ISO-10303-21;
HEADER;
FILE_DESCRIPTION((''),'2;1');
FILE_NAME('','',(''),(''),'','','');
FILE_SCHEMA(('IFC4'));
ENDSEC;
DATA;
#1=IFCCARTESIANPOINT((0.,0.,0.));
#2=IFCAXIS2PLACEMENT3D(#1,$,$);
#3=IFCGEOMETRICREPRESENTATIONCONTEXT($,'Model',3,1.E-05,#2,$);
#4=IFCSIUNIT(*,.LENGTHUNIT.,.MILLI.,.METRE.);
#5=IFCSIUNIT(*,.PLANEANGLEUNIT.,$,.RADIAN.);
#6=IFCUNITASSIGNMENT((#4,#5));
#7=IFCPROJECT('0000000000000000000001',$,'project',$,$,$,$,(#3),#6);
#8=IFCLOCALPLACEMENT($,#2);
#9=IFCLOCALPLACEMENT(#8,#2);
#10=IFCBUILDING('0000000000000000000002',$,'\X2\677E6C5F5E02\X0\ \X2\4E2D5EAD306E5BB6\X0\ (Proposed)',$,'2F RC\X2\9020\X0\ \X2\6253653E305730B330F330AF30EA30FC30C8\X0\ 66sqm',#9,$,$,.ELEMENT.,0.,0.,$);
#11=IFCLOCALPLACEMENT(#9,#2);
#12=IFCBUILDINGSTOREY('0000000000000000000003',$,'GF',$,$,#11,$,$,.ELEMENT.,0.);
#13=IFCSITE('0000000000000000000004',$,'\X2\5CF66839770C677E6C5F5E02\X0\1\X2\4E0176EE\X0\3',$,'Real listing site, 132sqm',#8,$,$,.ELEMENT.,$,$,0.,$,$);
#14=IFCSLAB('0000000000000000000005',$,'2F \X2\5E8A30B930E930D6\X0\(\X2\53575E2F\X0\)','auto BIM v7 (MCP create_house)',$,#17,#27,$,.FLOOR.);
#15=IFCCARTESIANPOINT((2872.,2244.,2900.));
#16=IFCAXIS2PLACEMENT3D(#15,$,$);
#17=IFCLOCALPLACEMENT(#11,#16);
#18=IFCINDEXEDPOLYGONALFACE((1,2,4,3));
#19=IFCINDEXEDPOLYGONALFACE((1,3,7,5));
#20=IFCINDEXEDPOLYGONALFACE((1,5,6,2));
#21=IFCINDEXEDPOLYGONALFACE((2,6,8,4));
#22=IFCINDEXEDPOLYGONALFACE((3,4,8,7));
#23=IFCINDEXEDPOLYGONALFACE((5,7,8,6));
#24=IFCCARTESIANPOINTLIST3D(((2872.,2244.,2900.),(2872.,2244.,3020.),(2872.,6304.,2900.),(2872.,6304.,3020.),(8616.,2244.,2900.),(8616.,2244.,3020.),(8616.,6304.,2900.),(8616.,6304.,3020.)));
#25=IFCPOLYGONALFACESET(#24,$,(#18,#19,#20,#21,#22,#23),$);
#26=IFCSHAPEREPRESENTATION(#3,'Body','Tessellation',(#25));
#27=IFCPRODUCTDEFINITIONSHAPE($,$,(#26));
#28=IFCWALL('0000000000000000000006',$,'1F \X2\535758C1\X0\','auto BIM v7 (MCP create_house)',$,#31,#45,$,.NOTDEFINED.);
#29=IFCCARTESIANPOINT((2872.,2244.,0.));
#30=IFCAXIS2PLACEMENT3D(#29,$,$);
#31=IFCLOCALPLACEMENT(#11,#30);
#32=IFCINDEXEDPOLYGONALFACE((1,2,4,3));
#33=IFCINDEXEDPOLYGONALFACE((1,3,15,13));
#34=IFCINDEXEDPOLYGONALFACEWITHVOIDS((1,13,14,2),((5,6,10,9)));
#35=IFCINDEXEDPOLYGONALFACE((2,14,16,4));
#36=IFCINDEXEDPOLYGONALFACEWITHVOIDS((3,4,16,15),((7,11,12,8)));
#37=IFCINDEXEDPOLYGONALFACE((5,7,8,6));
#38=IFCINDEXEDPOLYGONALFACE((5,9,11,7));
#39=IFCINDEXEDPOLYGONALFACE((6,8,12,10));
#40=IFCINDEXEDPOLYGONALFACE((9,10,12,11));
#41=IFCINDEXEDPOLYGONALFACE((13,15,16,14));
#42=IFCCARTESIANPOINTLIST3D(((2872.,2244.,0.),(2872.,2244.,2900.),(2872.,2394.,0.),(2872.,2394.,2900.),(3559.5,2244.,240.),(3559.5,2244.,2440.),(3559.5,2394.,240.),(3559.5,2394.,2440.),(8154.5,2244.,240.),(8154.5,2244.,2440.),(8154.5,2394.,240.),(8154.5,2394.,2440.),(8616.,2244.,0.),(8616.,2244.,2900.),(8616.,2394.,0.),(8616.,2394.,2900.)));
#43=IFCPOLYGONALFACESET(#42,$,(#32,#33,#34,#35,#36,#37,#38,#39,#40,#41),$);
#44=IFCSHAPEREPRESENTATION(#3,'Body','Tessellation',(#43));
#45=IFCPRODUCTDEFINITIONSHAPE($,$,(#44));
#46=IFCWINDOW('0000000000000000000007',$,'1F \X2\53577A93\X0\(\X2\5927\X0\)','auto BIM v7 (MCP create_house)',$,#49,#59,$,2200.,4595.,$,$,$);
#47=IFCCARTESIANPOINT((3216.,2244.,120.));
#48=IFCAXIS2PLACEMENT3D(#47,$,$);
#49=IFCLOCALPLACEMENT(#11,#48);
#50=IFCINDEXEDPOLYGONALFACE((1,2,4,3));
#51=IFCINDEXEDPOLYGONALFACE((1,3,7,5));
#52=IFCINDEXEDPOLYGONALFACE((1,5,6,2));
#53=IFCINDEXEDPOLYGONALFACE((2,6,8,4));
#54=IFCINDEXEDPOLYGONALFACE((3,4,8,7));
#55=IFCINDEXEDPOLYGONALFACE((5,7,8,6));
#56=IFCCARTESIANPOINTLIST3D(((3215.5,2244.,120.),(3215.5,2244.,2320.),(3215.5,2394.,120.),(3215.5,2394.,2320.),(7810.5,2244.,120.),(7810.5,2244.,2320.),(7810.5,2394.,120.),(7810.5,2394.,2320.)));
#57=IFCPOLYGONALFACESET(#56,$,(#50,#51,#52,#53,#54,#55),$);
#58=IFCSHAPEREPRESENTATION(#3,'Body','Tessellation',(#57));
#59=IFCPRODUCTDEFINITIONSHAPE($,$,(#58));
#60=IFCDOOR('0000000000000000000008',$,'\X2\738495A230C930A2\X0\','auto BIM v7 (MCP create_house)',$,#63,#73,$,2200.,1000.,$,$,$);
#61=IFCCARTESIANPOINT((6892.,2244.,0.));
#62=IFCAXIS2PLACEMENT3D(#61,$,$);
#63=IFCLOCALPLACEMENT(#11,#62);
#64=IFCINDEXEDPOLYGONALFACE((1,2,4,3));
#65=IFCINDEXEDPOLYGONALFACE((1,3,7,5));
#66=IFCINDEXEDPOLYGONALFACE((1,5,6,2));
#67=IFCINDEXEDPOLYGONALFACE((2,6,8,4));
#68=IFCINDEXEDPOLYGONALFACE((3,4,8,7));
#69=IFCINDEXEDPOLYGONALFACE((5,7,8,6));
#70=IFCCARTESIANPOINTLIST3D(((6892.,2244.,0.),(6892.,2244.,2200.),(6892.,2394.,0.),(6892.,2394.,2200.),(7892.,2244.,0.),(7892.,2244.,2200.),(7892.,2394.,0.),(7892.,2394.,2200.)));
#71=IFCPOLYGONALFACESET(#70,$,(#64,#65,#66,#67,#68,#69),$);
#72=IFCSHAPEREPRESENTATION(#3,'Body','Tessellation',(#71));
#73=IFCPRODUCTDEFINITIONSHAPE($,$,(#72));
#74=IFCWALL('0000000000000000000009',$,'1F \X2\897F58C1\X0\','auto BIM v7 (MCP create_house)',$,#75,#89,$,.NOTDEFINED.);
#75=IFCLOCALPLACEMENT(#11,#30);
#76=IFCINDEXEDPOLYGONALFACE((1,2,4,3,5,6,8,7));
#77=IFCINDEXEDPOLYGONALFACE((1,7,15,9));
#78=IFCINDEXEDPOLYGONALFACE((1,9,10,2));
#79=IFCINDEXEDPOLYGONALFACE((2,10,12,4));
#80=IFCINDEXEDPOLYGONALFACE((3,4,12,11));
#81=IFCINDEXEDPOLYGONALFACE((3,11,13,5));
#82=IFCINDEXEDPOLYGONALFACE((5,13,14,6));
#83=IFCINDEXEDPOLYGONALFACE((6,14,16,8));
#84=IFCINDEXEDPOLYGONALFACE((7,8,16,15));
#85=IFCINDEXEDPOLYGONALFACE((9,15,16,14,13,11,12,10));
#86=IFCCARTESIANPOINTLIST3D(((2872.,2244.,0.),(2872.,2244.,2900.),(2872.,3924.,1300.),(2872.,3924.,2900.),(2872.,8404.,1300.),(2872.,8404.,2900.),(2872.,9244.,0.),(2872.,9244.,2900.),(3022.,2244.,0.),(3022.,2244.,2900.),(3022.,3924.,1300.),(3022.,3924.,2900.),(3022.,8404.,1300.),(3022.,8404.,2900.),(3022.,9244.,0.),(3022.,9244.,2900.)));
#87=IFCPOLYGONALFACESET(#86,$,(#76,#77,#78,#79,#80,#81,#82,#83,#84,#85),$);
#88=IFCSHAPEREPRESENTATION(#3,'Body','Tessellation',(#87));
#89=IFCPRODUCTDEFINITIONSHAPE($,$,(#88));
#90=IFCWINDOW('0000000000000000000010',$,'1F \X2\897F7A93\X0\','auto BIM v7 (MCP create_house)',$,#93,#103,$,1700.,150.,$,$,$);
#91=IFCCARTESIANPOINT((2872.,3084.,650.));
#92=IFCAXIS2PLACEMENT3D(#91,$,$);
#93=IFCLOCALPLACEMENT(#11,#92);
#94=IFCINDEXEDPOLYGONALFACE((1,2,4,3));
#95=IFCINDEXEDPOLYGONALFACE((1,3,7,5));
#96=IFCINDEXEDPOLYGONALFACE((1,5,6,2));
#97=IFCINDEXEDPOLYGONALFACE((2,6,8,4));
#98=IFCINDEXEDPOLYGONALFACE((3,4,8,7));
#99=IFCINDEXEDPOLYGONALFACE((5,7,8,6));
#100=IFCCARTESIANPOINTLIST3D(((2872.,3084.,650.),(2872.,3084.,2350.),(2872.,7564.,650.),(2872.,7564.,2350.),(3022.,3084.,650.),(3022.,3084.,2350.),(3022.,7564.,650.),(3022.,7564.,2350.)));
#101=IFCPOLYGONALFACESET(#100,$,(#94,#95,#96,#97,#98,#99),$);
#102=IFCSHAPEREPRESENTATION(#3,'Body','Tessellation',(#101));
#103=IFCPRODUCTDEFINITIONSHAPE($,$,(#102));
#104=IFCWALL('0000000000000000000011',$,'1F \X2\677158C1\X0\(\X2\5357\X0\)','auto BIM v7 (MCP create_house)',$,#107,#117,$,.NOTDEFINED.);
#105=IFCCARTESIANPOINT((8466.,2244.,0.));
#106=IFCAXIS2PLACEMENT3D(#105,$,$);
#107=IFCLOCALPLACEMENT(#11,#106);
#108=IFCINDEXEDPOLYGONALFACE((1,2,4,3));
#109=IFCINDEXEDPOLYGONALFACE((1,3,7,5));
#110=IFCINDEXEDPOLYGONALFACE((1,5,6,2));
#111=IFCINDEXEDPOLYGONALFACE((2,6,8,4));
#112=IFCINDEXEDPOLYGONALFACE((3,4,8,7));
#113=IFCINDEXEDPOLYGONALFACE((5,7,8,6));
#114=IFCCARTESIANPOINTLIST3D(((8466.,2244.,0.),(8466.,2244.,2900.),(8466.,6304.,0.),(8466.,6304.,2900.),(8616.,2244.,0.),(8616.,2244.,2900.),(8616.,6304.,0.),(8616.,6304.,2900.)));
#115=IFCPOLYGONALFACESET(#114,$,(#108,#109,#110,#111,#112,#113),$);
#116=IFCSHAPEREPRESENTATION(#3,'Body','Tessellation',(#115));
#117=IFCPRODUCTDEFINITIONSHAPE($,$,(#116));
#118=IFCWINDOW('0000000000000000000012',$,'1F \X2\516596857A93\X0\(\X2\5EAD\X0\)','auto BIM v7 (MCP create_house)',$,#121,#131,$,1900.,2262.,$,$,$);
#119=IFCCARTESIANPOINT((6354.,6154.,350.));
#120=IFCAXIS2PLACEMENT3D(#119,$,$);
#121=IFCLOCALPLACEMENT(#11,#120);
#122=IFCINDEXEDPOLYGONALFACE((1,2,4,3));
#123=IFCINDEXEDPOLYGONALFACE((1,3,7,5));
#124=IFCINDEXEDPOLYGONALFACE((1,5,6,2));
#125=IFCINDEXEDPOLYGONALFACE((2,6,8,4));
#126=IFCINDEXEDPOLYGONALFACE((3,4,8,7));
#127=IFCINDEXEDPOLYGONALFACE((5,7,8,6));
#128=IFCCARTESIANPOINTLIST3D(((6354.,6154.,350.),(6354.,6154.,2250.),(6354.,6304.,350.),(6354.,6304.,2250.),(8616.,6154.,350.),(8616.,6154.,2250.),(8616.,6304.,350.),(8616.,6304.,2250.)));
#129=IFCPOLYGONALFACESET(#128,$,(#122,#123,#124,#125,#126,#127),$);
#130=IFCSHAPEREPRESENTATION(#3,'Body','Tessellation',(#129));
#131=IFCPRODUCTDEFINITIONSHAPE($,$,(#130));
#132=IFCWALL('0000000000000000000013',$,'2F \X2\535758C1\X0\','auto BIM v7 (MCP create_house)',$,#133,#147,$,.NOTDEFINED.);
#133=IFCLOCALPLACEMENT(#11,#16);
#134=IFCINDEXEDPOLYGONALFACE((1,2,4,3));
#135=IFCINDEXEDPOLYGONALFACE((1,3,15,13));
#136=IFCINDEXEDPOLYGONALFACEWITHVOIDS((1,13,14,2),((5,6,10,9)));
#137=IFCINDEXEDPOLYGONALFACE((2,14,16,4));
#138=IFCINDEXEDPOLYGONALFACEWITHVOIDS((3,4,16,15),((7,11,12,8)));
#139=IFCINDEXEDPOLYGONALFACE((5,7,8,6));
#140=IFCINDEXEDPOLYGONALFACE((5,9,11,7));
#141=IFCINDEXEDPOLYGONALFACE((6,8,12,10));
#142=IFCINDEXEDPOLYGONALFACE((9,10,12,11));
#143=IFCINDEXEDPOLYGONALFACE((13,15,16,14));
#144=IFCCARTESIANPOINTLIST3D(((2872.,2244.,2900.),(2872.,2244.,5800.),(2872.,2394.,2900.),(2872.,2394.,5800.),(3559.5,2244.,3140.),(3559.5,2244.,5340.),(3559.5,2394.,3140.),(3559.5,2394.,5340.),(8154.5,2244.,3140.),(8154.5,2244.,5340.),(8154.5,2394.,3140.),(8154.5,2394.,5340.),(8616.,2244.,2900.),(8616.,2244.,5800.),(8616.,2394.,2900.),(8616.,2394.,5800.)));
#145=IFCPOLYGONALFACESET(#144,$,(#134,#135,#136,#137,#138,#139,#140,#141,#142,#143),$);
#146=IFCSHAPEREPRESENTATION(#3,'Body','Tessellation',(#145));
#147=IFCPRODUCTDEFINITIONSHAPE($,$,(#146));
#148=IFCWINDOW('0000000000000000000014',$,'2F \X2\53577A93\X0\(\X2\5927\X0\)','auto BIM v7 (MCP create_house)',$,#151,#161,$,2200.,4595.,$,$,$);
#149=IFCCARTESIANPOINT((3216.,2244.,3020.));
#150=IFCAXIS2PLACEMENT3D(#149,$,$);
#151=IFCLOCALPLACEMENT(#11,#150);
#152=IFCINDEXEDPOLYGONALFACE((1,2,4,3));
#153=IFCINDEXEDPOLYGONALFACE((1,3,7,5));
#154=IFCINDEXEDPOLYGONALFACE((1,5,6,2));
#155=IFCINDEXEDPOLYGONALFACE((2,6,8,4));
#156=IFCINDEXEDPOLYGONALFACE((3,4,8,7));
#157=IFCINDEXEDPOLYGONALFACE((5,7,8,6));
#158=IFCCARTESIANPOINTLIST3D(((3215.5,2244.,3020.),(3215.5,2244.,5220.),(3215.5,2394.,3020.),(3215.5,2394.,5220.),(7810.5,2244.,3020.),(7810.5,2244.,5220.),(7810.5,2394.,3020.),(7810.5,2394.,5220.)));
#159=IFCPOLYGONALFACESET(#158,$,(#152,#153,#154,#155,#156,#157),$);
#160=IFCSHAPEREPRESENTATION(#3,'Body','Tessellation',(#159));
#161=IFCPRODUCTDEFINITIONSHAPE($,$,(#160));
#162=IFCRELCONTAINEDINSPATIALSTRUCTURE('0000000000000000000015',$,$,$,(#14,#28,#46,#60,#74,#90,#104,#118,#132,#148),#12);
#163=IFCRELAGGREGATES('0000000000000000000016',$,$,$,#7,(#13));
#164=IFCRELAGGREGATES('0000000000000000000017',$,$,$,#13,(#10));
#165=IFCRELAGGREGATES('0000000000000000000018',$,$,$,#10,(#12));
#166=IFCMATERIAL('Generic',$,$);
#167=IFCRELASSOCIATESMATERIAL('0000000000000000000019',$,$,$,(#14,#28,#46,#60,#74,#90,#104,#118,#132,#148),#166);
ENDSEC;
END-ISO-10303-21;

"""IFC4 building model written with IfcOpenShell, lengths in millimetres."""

from ifc_helpers import new_model, si_unit, frame, frame_2d, origin, place, context, project, spatial, rectangle, extrude, material, element, fill, save


model = new_model("IFC4")

# Units and contexts
model_context = context("Model", 3, precision=1e-05, world=origin())
ifc_project = project(units=[si_unit("LENGTHUNIT", "METRE", prefix="MILLI"), si_unit("PLANEANGLEUNIT", "RADIAN")], contexts=[model_context])

# Site, building, storey
site_placement = place(None, origin())
site = spatial("IfcSite", under=ifc_project, at=site_placement, Name="島根県松江市1丁目3", ObjectType="Real listing site, 132sqm", CompositionType="ELEMENT", RefElevation=0.0)
building_placement = place(site_placement, origin())
building = spatial("IfcBuilding", under=site, at=building_placement, Name="松江市 中庭の家 (Proposed)", ObjectType="2F RC造 打放しコンクリート 66sqm", CompositionType="ELEMENT", ElevationOfRefHeight=0.0, ElevationOfTerrain=0.0)
storey_placement = place(building_placement, origin())
storey = spatial("IfcBuildingStorey", under=building, at=storey_placement, Name="GF", CompositionType="ELEMENT", Elevation=0.0)

# Slab
ifc_material = material(Name="Generic")
slab_1_placement = place(storey_placement, frame((2872.0, 2244.0, 2900.0)))
element("IfcSlab", 1, at=slab_1_placement, inside=storey, material=ifc_material, Name="2F 床スラブ(南帯)", Description="auto BIM v7 (MCP create_house)", PredefinedType="FLOOR", context=model_context, shape_type="SweptSolid", body=[
    extrude(rectangle(XDim=5744.0, YDim=4060.0, at=frame_2d((2872.0, 2030.0))), frame((2872.0, 2244.0, 2900.0)), (0.0, 0.0, 1.0), 120.0),
])

# Wall, openings, window, door
wall_1_placement = place(storey_placement, frame((2872.0, 2244.0, 0.0)))
wall_1 = element("IfcWall", 2, at=wall_1_placement, inside=storey, material=ifc_material, Name="1F 南壁", Description="auto BIM v7 (MCP create_house)", PredefinedType="NOTDEFINED", context=model_context, shape_type="SweptSolid", body=[
    extrude(rectangle(XDim=5744.0, YDim=150.0, at=frame_2d((2872.0, 75.0))), frame((2872.0, 2244.0, 0.0)), (0.0, 0.0, 1.0), 2900.0),
])
opening_1_placement = place(storey_placement, frame((3216.0, 2244.0, 120.0)))
opening_1 = element("IfcOpeningElement", 3, at=opening_1_placement, cuts=wall_1, PredefinedType="NOTDEFINED", context=model_context, shape_type="SweptSolid", body=[
    extrude(rectangle(XDim=4595.0, YDim=150.0, at=frame_2d((2297.0, 75.0))), frame((3216.0, 2244.0, 120.0)), (0.0, 0.0, 1.0), 2200.0),
])
opening_2_placement = place(storey_placement, frame((6892.0, 2244.0, 0.0)))
opening_2 = element("IfcOpeningElement", 4, at=opening_2_placement, cuts=wall_1, PredefinedType="NOTDEFINED", context=model_context, shape_type="SweptSolid", body=[
    extrude(rectangle(XDim=1000.0, YDim=150.0, at=frame_2d((500.0, 75.0))), frame((6892.0, 2244.0, 0.0)), (0.0, 0.0, 1.0), 2200.0),
])
window_1_placement = place(storey_placement, frame((3216.0, 2244.0, 120.0)))
window_1 = element("IfcWindow", 5, at=window_1_placement, inside=storey, material=ifc_material, Name="1F 南窓(大)", Description="auto BIM v7 (MCP create_house)", OverallHeight=2200.0, OverallWidth=4595.0, context=model_context, shape_type="SweptSolid", body=[
    extrude(rectangle(XDim=4595.0, YDim=150.0, at=frame_2d((2297.0, 75.0))), frame((3216.0, 2244.0, 120.0)), (0.0, 0.0, 1.0), 2200.0),
])
fill(opening_1, window_1)
door_placement = place(storey_placement, frame((6892.0, 2244.0, 0.0)))
door = element("IfcDoor", 6, at=door_placement, inside=storey, material=ifc_material, Name="玄関ドア", Description="auto BIM v7 (MCP create_house)", OverallHeight=2200.0, OverallWidth=1000.0, context=model_context, shape_type="SweptSolid", body=[
    extrude(rectangle(XDim=1000.0, YDim=150.0, at=frame_2d((500.0, 75.0))), frame((6892.0, 2244.0, 0.0)), (0.0, 0.0, 1.0), 2200.0),
])
fill(opening_2, door)

# Walls, openings, windows
wall_2_placement = place(storey_placement, frame((2872.0, 2244.0, 0.0)))
wall_2 = element("IfcWall", 7, at=wall_2_placement, inside=storey, material=ifc_material, Name="1F 西壁", Description="auto BIM v7 (MCP create_house)", PredefinedType="NOTDEFINED", context=model_context, shape_type="SweptSolid", body=[
    extrude(rectangle(XDim=150.0, YDim=7000.0, at=frame_2d((75.0, 3500.0))), frame((2872.0, 2244.0, 0.0)), (0.0, 0.0, 1.0), 2900.0),
])
opening_3_placement = place(storey_placement, frame((2872.0, 3084.0, 650.0)))
opening_3 = element("IfcOpeningElement", 8, at=opening_3_placement, cuts=wall_2, PredefinedType="NOTDEFINED", context=model_context, shape_type="SweptSolid", body=[
    extrude(rectangle(XDim=150.0, YDim=4480.0, at=frame_2d((75.0, 2240.0))), frame((2872.0, 3084.0, 650.0)), (0.0, 0.0, 1.0), 1700.0),
])
window_2_placement = place(storey_placement, frame((2872.0, 3084.0, 650.0)))
window_2 = element("IfcWindow", 9, at=window_2_placement, inside=storey, material=ifc_material, Name="1F 西窓", Description="auto BIM v7 (MCP create_house)", OverallHeight=1700.0, OverallWidth=150.0, context=model_context, shape_type="SweptSolid", body=[
    extrude(rectangle(XDim=150.0, YDim=4480.0, at=frame_2d((75.0, 2240.0))), frame((2872.0, 3084.0, 650.0)), (0.0, 0.0, 1.0), 1700.0),
])
fill(opening_3, window_2)
wall_3_placement = place(storey_placement, frame((8466.0, 2244.0, 0.0)))
wall_3 = element("IfcWall", 10, at=wall_3_placement, inside=storey, material=ifc_material, Name="1F 東壁(南)", Description="auto BIM v7 (MCP create_house)", PredefinedType="NOTDEFINED", context=model_context, shape_type="SweptSolid", body=[
    extrude(rectangle(XDim=150.0, YDim=4060.0, at=frame_2d((75.0, 2030.0))), frame((8466.0, 2244.0, 0.0)), (0.0, 0.0, 1.0), 2900.0),
])
opening_4_placement = place(storey_placement, frame((6354.0, 6154.0, 350.0)))
opening_4 = element("IfcOpeningElement", 11, at=opening_4_placement, cuts=wall_3, PredefinedType="NOTDEFINED", context=model_context, shape_type="SweptSolid", body=[
    extrude(rectangle(XDim=2262.0, YDim=150.0, at=frame_2d((1131.0, 75.0))), frame((6354.0, 6154.0, 350.0)), (0.0, 0.0, 1.0), 1900.0),
])
window_3_placement = place(storey_placement, frame((6354.0, 6154.0, 350.0)))
window_3 = element("IfcWindow", 12, at=window_3_placement, inside=storey, material=ifc_material, Name="1F 入隅窓(庭)", Description="auto BIM v7 (MCP create_house)", OverallHeight=1900.0, OverallWidth=2262.0, context=model_context, shape_type="SweptSolid", body=[
    extrude(rectangle(XDim=2262.0, YDim=150.0, at=frame_2d((1131.0, 75.0))), frame((6354.0, 6154.0, 350.0)), (0.0, 0.0, 1.0), 1900.0),
])
fill(opening_4, window_3)

# Wall, opening, window
wall_4_placement = place(storey_placement, frame((2872.0, 2244.0, 2900.0)))
wall_4 = element("IfcWall", 13, at=wall_4_placement, inside=storey, material=ifc_material, Name="2F 南壁", Description="auto BIM v7 (MCP create_house)", PredefinedType="NOTDEFINED", context=model_context, shape_type="SweptSolid", body=[
    extrude(rectangle(XDim=5744.0, YDim=150.0, at=frame_2d((2872.0, 75.0))), frame((2872.0, 2244.0, 2900.0)), (0.0, 0.0, 1.0), 2900.0),
])
opening_5_placement = place(storey_placement, frame((3216.0, 2244.0, 3020.0)))
opening_5 = element("IfcOpeningElement", 14, at=opening_5_placement, cuts=wall_4, PredefinedType="NOTDEFINED", context=model_context, shape_type="SweptSolid", body=[
    extrude(rectangle(XDim=4595.0, YDim=150.0, at=frame_2d((2297.0, 75.0))), frame((3216.0, 2244.0, 3020.0)), (0.0, 0.0, 1.0), 2200.0),
])
window_4_placement = place(storey_placement, frame((3216.0, 2244.0, 3020.0)))
window_4 = element("IfcWindow", 15, at=window_4_placement, inside=storey, material=ifc_material, Name="2F 南窓(大)", Description="auto BIM v7 (MCP create_house)", OverallHeight=2200.0, OverallWidth=4595.0, context=model_context, shape_type="SweptSolid", body=[
    extrude(rectangle(XDim=4595.0, YDim=150.0, at=frame_2d((2297.0, 75.0))), frame((3216.0, 2244.0, 3020.0)), (0.0, 0.0, 1.0), 2200.0),
])
fill(opening_5, window_4)

save(model, "model.ifc")
